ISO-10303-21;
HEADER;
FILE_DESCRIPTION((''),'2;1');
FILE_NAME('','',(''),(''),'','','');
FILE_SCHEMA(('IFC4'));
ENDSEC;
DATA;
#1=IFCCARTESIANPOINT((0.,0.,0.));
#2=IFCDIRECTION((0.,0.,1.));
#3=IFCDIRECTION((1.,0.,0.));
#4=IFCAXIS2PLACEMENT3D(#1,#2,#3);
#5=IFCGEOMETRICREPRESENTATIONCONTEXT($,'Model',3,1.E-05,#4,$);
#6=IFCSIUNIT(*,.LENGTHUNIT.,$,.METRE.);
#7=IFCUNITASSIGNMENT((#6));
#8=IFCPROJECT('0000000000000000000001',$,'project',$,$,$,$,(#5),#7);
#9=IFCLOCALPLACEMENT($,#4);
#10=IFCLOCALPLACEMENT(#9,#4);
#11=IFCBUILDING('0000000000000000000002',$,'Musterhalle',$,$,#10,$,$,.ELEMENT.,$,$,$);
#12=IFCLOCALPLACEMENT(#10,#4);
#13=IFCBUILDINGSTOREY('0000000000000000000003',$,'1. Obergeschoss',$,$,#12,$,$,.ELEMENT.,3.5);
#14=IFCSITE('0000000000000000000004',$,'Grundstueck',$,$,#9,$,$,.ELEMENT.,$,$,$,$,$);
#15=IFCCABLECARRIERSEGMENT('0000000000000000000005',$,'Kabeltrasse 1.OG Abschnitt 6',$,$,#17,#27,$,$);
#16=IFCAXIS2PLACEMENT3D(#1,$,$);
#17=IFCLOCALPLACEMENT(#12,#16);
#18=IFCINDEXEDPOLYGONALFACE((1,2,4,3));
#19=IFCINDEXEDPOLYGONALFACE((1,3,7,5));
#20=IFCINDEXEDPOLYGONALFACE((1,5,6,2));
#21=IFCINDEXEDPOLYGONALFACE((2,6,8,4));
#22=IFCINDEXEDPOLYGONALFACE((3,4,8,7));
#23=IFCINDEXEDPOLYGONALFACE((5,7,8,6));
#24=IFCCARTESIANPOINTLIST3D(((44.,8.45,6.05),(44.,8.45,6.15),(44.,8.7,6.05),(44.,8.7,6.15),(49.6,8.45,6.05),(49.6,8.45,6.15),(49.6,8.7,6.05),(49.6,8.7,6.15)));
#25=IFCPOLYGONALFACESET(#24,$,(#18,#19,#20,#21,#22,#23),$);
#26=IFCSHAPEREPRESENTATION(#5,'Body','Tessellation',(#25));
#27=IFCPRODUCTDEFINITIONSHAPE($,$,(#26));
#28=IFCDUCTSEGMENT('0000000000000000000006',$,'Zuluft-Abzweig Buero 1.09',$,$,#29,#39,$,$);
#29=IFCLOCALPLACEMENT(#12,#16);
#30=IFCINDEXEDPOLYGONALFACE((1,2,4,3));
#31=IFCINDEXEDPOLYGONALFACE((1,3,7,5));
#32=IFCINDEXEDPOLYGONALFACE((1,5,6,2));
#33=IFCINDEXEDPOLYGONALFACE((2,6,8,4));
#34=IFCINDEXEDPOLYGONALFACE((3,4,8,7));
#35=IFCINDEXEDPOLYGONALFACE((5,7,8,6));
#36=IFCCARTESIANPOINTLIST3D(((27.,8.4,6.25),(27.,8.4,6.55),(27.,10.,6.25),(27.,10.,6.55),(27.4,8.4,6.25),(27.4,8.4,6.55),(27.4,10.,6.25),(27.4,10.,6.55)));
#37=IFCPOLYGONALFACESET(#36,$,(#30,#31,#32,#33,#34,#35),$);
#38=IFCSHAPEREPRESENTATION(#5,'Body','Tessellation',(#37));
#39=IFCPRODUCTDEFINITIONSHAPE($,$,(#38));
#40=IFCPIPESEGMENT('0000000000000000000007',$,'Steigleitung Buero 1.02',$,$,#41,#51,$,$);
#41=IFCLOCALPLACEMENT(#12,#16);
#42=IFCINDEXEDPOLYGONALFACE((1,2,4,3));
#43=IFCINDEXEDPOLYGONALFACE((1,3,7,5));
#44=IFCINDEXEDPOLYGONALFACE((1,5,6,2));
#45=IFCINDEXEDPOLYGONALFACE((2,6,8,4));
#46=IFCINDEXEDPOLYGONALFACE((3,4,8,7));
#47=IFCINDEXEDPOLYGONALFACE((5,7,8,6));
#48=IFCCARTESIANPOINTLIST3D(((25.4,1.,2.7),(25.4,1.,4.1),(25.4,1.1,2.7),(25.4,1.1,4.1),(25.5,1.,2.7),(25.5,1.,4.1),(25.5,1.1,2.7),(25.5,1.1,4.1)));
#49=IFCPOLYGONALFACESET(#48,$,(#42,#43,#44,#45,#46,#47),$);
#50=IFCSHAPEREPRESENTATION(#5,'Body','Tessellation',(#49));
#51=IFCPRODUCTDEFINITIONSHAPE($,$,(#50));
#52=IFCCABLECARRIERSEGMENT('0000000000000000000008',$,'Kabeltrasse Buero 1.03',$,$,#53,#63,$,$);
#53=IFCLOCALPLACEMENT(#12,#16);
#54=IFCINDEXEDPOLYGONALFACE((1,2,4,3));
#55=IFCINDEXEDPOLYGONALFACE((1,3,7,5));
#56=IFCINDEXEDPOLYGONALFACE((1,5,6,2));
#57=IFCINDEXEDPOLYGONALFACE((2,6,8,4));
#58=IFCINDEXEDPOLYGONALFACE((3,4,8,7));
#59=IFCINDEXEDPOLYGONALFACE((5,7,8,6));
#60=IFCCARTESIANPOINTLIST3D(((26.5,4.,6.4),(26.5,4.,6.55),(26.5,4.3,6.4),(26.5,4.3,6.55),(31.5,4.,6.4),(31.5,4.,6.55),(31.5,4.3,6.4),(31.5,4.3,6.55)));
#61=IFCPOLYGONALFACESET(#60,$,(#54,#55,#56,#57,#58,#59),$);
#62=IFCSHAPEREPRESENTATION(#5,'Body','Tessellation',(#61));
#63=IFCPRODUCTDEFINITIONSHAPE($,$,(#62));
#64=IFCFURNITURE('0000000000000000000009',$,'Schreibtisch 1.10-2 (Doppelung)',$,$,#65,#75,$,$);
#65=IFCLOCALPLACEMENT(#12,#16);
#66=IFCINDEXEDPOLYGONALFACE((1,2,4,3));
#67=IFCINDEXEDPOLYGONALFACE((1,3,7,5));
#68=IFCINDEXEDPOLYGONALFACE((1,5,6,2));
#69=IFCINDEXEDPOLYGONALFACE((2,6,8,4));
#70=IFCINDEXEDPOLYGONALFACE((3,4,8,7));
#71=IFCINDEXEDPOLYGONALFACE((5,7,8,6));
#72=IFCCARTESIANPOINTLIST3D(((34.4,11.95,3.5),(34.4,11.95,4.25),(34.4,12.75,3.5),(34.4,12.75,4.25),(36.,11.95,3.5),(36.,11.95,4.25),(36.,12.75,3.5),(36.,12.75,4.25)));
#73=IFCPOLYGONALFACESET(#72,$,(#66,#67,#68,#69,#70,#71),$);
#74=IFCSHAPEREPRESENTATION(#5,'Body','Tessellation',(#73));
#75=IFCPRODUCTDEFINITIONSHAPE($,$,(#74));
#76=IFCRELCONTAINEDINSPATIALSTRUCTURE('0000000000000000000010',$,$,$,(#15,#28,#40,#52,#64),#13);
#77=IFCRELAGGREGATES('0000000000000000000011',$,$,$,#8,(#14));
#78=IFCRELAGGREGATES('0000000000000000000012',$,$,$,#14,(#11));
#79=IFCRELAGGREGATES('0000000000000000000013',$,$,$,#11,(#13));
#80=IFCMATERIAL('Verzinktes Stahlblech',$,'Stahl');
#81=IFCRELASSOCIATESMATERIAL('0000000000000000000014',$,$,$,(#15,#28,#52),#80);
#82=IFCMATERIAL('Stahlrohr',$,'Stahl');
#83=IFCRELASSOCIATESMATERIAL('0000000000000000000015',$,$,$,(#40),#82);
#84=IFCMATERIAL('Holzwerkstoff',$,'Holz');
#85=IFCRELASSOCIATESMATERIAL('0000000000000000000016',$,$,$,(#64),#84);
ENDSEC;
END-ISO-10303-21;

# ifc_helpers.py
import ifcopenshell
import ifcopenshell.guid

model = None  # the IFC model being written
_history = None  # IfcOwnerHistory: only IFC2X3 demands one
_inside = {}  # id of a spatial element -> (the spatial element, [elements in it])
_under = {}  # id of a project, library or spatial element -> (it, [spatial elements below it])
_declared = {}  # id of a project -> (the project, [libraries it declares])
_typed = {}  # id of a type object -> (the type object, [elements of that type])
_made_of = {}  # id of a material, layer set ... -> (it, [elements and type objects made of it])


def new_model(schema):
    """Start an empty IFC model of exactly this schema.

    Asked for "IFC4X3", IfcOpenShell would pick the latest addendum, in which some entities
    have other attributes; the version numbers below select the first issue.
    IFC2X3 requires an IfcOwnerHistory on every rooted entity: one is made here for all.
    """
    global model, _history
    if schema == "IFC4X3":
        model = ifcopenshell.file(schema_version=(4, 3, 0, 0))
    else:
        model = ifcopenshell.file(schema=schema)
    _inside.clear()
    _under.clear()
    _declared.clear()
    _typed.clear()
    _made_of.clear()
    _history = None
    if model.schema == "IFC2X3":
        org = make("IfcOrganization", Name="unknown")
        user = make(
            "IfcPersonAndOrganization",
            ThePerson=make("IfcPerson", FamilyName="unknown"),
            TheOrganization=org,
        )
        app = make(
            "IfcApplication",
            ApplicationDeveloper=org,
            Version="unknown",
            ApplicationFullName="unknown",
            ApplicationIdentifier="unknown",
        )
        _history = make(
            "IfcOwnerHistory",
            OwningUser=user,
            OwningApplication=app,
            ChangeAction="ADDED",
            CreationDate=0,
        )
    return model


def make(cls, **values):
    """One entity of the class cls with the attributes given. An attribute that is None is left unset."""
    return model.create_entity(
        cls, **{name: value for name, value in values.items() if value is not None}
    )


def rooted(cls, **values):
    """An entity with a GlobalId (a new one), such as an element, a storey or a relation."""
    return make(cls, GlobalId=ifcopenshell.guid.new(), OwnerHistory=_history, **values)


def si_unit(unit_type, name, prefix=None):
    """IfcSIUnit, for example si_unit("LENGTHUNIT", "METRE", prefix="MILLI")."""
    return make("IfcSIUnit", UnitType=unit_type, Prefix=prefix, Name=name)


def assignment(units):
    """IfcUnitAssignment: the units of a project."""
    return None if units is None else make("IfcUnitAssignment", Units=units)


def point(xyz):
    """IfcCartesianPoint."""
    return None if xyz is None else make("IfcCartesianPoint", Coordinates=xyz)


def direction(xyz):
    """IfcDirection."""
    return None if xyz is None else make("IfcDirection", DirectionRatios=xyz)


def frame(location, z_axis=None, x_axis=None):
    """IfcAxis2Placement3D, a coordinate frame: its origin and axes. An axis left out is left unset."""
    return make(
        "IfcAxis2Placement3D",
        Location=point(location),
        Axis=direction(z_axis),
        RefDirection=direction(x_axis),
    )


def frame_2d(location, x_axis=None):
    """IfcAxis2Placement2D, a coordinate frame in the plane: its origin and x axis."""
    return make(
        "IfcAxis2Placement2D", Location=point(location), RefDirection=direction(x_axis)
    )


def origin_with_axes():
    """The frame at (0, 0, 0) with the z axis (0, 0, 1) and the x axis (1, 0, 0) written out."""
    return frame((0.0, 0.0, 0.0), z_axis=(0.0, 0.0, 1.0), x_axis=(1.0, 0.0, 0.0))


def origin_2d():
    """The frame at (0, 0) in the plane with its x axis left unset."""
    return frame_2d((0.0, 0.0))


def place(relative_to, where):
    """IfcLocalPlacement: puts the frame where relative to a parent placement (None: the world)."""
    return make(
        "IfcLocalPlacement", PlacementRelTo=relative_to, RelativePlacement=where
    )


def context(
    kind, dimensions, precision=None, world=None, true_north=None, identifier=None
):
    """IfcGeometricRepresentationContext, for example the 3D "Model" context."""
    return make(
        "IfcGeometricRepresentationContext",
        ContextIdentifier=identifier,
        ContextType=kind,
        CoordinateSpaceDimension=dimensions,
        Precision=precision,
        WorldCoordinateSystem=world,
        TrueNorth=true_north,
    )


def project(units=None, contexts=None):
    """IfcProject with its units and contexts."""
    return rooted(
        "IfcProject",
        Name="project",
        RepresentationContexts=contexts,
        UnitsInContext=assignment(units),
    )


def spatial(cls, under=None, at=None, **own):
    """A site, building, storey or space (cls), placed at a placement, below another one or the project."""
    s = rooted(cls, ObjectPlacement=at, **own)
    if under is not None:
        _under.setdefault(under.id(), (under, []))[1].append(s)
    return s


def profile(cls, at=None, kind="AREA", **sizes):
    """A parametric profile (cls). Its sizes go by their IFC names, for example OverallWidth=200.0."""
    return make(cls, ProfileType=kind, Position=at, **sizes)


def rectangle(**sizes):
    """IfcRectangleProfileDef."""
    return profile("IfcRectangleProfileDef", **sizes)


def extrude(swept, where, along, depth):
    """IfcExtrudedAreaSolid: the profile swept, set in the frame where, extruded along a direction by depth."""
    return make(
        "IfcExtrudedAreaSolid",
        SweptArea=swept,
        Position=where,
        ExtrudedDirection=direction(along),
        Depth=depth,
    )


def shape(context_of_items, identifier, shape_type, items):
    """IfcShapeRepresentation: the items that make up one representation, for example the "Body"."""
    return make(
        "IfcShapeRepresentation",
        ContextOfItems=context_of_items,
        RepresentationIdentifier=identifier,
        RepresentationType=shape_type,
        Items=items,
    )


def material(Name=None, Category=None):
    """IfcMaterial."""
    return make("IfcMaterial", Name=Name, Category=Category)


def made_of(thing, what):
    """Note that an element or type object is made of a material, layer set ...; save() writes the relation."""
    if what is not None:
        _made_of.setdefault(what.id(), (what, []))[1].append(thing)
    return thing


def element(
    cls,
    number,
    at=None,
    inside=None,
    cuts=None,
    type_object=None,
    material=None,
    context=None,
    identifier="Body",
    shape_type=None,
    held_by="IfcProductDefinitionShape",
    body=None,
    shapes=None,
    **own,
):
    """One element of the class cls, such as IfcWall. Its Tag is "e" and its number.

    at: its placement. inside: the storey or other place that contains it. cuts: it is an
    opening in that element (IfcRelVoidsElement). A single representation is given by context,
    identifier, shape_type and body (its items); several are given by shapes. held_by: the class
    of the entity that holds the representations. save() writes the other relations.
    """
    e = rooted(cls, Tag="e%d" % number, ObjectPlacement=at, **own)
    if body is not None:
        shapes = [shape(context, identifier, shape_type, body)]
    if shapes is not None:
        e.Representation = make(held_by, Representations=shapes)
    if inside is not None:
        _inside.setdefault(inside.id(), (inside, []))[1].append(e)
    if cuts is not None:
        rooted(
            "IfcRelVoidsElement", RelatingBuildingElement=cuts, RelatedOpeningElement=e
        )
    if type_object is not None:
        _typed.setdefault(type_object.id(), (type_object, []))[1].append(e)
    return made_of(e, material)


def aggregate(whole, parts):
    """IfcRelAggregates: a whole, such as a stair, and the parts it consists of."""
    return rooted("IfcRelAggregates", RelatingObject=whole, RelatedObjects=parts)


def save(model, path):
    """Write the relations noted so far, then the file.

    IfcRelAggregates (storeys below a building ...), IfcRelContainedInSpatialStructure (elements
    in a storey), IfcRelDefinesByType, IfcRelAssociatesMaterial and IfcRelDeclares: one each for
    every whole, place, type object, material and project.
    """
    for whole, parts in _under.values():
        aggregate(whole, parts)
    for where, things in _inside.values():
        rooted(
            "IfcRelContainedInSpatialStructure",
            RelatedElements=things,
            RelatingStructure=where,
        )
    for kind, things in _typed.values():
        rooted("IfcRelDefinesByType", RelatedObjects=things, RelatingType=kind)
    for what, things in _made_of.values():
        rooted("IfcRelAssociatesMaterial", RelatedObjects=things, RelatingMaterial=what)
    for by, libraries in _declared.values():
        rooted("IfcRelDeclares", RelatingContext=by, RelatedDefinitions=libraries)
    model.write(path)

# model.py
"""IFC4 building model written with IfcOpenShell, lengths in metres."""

from ifc_helpers import new_model, si_unit, frame, origin_with_axes, origin_2d, place, context, project, spatial, rectangle, extrude, material, element, save


model = new_model("IFC4")

# Units and contexts
model_context = context("Model", 3, precision=1e-05, world=origin_with_axes())
ifc_project = project(units=[si_unit("LENGTHUNIT", "METRE")], contexts=[model_context])

# Site, building, storey
site_placement = place(None, origin_with_axes())
site = spatial("IfcSite", under=ifc_project, at=site_placement, Name="Grundstueck", CompositionType="ELEMENT")
building_placement = place(site_placement, origin_with_axes())
building = spatial("IfcBuilding", under=site, at=building_placement, Name="Musterhalle", CompositionType="ELEMENT")
storey_placement = place(building_placement, origin_with_axes())
storey = spatial("IfcBuildingStorey", under=building, at=storey_placement, Name="1. Obergeschoss", CompositionType="ELEMENT", Elevation=3.5)

# Shared definitions
placement = place(storey_placement, origin_with_axes())

# Shared definitions
ifc_material_1 = material(Name="Verzinktes Stahlblech", Category="Stahl")

# Shared definitions
ifc_material_2 = material(Name="Stahlrohr", Category="Stahl")

# Cable carrier segment
element("IfcCableCarrierSegment", 1, at=placement, inside=storey, material=ifc_material_1, Name="Kabeltrasse 1.OG Abschnitt 6", context=model_context, shape_type="SweptSolid", body=[
    extrude(rectangle(XDim=5.6, YDim=0.25, at=origin_2d()), frame((46.8, 8.575, 6.05), z_axis=(0.0, 0.0, 1.0), x_axis=(1.0, 0.0, 0.0)), (0.0, 0.0, 1.0), 0.1),
])

# Duct segment
element("IfcDuctSegment", 2, at=placement, inside=storey, material=ifc_material_1, Name="Zuluft-Abzweig Buero 1.09", context=model_context, shape_type="SweptSolid", body=[
    extrude(rectangle(XDim=0.4, YDim=1.6, at=origin_2d()), frame((27.2, 9.2, 6.25), z_axis=(0.0, 0.0, 1.0), x_axis=(1.0, 0.0, 0.0)), (0.0, 0.0, 1.0), 0.3),
])

# Pipe segment
element("IfcPipeSegment", 3, at=placement, inside=storey, material=ifc_material_2, Name="Steigleitung Buero 1.02", context=model_context, shape_type="SweptSolid", body=[
    extrude(rectangle(XDim=0.1, YDim=0.1, at=origin_2d()), frame((25.45, 1.05, 2.7), z_axis=(0.0, 0.0, 1.0), x_axis=(1.0, 0.0, 0.0)), (0.0, 0.0, 1.0), 1.4),
])

# Cable carrier segment
element("IfcCableCarrierSegment", 4, at=placement, inside=storey, material=ifc_material_1, Name="Kabeltrasse Buero 1.03", context=model_context, shape_type="SweptSolid", body=[
    extrude(rectangle(XDim=5.0, YDim=0.3, at=origin_2d()), frame((29.0, 4.15, 6.4), z_axis=(0.0, 0.0, 1.0), x_axis=(1.0, 0.0, 0.0)), (0.0, 0.0, 1.0), 0.15),
])

# Furniture
ifc_material_3 = material(Name="Holzwerkstoff", Category="Holz")
element("IfcFurniture", 5, at=placement, inside=storey, material=ifc_material_3, Name="Schreibtisch 1.10-2 (Doppelung)", context=model_context, shape_type="SweptSolid", body=[
    extrude(rectangle(XDim=1.6, YDim=0.8, at=origin_2d()), frame((35.2, 12.35, 3.5), z_axis=(0.0, 0.0, 1.0), x_axis=(1.0, 0.0, 0.0)), (0.0, 0.0, 1.0), 0.75),
])

save(model, "model.ifc")
